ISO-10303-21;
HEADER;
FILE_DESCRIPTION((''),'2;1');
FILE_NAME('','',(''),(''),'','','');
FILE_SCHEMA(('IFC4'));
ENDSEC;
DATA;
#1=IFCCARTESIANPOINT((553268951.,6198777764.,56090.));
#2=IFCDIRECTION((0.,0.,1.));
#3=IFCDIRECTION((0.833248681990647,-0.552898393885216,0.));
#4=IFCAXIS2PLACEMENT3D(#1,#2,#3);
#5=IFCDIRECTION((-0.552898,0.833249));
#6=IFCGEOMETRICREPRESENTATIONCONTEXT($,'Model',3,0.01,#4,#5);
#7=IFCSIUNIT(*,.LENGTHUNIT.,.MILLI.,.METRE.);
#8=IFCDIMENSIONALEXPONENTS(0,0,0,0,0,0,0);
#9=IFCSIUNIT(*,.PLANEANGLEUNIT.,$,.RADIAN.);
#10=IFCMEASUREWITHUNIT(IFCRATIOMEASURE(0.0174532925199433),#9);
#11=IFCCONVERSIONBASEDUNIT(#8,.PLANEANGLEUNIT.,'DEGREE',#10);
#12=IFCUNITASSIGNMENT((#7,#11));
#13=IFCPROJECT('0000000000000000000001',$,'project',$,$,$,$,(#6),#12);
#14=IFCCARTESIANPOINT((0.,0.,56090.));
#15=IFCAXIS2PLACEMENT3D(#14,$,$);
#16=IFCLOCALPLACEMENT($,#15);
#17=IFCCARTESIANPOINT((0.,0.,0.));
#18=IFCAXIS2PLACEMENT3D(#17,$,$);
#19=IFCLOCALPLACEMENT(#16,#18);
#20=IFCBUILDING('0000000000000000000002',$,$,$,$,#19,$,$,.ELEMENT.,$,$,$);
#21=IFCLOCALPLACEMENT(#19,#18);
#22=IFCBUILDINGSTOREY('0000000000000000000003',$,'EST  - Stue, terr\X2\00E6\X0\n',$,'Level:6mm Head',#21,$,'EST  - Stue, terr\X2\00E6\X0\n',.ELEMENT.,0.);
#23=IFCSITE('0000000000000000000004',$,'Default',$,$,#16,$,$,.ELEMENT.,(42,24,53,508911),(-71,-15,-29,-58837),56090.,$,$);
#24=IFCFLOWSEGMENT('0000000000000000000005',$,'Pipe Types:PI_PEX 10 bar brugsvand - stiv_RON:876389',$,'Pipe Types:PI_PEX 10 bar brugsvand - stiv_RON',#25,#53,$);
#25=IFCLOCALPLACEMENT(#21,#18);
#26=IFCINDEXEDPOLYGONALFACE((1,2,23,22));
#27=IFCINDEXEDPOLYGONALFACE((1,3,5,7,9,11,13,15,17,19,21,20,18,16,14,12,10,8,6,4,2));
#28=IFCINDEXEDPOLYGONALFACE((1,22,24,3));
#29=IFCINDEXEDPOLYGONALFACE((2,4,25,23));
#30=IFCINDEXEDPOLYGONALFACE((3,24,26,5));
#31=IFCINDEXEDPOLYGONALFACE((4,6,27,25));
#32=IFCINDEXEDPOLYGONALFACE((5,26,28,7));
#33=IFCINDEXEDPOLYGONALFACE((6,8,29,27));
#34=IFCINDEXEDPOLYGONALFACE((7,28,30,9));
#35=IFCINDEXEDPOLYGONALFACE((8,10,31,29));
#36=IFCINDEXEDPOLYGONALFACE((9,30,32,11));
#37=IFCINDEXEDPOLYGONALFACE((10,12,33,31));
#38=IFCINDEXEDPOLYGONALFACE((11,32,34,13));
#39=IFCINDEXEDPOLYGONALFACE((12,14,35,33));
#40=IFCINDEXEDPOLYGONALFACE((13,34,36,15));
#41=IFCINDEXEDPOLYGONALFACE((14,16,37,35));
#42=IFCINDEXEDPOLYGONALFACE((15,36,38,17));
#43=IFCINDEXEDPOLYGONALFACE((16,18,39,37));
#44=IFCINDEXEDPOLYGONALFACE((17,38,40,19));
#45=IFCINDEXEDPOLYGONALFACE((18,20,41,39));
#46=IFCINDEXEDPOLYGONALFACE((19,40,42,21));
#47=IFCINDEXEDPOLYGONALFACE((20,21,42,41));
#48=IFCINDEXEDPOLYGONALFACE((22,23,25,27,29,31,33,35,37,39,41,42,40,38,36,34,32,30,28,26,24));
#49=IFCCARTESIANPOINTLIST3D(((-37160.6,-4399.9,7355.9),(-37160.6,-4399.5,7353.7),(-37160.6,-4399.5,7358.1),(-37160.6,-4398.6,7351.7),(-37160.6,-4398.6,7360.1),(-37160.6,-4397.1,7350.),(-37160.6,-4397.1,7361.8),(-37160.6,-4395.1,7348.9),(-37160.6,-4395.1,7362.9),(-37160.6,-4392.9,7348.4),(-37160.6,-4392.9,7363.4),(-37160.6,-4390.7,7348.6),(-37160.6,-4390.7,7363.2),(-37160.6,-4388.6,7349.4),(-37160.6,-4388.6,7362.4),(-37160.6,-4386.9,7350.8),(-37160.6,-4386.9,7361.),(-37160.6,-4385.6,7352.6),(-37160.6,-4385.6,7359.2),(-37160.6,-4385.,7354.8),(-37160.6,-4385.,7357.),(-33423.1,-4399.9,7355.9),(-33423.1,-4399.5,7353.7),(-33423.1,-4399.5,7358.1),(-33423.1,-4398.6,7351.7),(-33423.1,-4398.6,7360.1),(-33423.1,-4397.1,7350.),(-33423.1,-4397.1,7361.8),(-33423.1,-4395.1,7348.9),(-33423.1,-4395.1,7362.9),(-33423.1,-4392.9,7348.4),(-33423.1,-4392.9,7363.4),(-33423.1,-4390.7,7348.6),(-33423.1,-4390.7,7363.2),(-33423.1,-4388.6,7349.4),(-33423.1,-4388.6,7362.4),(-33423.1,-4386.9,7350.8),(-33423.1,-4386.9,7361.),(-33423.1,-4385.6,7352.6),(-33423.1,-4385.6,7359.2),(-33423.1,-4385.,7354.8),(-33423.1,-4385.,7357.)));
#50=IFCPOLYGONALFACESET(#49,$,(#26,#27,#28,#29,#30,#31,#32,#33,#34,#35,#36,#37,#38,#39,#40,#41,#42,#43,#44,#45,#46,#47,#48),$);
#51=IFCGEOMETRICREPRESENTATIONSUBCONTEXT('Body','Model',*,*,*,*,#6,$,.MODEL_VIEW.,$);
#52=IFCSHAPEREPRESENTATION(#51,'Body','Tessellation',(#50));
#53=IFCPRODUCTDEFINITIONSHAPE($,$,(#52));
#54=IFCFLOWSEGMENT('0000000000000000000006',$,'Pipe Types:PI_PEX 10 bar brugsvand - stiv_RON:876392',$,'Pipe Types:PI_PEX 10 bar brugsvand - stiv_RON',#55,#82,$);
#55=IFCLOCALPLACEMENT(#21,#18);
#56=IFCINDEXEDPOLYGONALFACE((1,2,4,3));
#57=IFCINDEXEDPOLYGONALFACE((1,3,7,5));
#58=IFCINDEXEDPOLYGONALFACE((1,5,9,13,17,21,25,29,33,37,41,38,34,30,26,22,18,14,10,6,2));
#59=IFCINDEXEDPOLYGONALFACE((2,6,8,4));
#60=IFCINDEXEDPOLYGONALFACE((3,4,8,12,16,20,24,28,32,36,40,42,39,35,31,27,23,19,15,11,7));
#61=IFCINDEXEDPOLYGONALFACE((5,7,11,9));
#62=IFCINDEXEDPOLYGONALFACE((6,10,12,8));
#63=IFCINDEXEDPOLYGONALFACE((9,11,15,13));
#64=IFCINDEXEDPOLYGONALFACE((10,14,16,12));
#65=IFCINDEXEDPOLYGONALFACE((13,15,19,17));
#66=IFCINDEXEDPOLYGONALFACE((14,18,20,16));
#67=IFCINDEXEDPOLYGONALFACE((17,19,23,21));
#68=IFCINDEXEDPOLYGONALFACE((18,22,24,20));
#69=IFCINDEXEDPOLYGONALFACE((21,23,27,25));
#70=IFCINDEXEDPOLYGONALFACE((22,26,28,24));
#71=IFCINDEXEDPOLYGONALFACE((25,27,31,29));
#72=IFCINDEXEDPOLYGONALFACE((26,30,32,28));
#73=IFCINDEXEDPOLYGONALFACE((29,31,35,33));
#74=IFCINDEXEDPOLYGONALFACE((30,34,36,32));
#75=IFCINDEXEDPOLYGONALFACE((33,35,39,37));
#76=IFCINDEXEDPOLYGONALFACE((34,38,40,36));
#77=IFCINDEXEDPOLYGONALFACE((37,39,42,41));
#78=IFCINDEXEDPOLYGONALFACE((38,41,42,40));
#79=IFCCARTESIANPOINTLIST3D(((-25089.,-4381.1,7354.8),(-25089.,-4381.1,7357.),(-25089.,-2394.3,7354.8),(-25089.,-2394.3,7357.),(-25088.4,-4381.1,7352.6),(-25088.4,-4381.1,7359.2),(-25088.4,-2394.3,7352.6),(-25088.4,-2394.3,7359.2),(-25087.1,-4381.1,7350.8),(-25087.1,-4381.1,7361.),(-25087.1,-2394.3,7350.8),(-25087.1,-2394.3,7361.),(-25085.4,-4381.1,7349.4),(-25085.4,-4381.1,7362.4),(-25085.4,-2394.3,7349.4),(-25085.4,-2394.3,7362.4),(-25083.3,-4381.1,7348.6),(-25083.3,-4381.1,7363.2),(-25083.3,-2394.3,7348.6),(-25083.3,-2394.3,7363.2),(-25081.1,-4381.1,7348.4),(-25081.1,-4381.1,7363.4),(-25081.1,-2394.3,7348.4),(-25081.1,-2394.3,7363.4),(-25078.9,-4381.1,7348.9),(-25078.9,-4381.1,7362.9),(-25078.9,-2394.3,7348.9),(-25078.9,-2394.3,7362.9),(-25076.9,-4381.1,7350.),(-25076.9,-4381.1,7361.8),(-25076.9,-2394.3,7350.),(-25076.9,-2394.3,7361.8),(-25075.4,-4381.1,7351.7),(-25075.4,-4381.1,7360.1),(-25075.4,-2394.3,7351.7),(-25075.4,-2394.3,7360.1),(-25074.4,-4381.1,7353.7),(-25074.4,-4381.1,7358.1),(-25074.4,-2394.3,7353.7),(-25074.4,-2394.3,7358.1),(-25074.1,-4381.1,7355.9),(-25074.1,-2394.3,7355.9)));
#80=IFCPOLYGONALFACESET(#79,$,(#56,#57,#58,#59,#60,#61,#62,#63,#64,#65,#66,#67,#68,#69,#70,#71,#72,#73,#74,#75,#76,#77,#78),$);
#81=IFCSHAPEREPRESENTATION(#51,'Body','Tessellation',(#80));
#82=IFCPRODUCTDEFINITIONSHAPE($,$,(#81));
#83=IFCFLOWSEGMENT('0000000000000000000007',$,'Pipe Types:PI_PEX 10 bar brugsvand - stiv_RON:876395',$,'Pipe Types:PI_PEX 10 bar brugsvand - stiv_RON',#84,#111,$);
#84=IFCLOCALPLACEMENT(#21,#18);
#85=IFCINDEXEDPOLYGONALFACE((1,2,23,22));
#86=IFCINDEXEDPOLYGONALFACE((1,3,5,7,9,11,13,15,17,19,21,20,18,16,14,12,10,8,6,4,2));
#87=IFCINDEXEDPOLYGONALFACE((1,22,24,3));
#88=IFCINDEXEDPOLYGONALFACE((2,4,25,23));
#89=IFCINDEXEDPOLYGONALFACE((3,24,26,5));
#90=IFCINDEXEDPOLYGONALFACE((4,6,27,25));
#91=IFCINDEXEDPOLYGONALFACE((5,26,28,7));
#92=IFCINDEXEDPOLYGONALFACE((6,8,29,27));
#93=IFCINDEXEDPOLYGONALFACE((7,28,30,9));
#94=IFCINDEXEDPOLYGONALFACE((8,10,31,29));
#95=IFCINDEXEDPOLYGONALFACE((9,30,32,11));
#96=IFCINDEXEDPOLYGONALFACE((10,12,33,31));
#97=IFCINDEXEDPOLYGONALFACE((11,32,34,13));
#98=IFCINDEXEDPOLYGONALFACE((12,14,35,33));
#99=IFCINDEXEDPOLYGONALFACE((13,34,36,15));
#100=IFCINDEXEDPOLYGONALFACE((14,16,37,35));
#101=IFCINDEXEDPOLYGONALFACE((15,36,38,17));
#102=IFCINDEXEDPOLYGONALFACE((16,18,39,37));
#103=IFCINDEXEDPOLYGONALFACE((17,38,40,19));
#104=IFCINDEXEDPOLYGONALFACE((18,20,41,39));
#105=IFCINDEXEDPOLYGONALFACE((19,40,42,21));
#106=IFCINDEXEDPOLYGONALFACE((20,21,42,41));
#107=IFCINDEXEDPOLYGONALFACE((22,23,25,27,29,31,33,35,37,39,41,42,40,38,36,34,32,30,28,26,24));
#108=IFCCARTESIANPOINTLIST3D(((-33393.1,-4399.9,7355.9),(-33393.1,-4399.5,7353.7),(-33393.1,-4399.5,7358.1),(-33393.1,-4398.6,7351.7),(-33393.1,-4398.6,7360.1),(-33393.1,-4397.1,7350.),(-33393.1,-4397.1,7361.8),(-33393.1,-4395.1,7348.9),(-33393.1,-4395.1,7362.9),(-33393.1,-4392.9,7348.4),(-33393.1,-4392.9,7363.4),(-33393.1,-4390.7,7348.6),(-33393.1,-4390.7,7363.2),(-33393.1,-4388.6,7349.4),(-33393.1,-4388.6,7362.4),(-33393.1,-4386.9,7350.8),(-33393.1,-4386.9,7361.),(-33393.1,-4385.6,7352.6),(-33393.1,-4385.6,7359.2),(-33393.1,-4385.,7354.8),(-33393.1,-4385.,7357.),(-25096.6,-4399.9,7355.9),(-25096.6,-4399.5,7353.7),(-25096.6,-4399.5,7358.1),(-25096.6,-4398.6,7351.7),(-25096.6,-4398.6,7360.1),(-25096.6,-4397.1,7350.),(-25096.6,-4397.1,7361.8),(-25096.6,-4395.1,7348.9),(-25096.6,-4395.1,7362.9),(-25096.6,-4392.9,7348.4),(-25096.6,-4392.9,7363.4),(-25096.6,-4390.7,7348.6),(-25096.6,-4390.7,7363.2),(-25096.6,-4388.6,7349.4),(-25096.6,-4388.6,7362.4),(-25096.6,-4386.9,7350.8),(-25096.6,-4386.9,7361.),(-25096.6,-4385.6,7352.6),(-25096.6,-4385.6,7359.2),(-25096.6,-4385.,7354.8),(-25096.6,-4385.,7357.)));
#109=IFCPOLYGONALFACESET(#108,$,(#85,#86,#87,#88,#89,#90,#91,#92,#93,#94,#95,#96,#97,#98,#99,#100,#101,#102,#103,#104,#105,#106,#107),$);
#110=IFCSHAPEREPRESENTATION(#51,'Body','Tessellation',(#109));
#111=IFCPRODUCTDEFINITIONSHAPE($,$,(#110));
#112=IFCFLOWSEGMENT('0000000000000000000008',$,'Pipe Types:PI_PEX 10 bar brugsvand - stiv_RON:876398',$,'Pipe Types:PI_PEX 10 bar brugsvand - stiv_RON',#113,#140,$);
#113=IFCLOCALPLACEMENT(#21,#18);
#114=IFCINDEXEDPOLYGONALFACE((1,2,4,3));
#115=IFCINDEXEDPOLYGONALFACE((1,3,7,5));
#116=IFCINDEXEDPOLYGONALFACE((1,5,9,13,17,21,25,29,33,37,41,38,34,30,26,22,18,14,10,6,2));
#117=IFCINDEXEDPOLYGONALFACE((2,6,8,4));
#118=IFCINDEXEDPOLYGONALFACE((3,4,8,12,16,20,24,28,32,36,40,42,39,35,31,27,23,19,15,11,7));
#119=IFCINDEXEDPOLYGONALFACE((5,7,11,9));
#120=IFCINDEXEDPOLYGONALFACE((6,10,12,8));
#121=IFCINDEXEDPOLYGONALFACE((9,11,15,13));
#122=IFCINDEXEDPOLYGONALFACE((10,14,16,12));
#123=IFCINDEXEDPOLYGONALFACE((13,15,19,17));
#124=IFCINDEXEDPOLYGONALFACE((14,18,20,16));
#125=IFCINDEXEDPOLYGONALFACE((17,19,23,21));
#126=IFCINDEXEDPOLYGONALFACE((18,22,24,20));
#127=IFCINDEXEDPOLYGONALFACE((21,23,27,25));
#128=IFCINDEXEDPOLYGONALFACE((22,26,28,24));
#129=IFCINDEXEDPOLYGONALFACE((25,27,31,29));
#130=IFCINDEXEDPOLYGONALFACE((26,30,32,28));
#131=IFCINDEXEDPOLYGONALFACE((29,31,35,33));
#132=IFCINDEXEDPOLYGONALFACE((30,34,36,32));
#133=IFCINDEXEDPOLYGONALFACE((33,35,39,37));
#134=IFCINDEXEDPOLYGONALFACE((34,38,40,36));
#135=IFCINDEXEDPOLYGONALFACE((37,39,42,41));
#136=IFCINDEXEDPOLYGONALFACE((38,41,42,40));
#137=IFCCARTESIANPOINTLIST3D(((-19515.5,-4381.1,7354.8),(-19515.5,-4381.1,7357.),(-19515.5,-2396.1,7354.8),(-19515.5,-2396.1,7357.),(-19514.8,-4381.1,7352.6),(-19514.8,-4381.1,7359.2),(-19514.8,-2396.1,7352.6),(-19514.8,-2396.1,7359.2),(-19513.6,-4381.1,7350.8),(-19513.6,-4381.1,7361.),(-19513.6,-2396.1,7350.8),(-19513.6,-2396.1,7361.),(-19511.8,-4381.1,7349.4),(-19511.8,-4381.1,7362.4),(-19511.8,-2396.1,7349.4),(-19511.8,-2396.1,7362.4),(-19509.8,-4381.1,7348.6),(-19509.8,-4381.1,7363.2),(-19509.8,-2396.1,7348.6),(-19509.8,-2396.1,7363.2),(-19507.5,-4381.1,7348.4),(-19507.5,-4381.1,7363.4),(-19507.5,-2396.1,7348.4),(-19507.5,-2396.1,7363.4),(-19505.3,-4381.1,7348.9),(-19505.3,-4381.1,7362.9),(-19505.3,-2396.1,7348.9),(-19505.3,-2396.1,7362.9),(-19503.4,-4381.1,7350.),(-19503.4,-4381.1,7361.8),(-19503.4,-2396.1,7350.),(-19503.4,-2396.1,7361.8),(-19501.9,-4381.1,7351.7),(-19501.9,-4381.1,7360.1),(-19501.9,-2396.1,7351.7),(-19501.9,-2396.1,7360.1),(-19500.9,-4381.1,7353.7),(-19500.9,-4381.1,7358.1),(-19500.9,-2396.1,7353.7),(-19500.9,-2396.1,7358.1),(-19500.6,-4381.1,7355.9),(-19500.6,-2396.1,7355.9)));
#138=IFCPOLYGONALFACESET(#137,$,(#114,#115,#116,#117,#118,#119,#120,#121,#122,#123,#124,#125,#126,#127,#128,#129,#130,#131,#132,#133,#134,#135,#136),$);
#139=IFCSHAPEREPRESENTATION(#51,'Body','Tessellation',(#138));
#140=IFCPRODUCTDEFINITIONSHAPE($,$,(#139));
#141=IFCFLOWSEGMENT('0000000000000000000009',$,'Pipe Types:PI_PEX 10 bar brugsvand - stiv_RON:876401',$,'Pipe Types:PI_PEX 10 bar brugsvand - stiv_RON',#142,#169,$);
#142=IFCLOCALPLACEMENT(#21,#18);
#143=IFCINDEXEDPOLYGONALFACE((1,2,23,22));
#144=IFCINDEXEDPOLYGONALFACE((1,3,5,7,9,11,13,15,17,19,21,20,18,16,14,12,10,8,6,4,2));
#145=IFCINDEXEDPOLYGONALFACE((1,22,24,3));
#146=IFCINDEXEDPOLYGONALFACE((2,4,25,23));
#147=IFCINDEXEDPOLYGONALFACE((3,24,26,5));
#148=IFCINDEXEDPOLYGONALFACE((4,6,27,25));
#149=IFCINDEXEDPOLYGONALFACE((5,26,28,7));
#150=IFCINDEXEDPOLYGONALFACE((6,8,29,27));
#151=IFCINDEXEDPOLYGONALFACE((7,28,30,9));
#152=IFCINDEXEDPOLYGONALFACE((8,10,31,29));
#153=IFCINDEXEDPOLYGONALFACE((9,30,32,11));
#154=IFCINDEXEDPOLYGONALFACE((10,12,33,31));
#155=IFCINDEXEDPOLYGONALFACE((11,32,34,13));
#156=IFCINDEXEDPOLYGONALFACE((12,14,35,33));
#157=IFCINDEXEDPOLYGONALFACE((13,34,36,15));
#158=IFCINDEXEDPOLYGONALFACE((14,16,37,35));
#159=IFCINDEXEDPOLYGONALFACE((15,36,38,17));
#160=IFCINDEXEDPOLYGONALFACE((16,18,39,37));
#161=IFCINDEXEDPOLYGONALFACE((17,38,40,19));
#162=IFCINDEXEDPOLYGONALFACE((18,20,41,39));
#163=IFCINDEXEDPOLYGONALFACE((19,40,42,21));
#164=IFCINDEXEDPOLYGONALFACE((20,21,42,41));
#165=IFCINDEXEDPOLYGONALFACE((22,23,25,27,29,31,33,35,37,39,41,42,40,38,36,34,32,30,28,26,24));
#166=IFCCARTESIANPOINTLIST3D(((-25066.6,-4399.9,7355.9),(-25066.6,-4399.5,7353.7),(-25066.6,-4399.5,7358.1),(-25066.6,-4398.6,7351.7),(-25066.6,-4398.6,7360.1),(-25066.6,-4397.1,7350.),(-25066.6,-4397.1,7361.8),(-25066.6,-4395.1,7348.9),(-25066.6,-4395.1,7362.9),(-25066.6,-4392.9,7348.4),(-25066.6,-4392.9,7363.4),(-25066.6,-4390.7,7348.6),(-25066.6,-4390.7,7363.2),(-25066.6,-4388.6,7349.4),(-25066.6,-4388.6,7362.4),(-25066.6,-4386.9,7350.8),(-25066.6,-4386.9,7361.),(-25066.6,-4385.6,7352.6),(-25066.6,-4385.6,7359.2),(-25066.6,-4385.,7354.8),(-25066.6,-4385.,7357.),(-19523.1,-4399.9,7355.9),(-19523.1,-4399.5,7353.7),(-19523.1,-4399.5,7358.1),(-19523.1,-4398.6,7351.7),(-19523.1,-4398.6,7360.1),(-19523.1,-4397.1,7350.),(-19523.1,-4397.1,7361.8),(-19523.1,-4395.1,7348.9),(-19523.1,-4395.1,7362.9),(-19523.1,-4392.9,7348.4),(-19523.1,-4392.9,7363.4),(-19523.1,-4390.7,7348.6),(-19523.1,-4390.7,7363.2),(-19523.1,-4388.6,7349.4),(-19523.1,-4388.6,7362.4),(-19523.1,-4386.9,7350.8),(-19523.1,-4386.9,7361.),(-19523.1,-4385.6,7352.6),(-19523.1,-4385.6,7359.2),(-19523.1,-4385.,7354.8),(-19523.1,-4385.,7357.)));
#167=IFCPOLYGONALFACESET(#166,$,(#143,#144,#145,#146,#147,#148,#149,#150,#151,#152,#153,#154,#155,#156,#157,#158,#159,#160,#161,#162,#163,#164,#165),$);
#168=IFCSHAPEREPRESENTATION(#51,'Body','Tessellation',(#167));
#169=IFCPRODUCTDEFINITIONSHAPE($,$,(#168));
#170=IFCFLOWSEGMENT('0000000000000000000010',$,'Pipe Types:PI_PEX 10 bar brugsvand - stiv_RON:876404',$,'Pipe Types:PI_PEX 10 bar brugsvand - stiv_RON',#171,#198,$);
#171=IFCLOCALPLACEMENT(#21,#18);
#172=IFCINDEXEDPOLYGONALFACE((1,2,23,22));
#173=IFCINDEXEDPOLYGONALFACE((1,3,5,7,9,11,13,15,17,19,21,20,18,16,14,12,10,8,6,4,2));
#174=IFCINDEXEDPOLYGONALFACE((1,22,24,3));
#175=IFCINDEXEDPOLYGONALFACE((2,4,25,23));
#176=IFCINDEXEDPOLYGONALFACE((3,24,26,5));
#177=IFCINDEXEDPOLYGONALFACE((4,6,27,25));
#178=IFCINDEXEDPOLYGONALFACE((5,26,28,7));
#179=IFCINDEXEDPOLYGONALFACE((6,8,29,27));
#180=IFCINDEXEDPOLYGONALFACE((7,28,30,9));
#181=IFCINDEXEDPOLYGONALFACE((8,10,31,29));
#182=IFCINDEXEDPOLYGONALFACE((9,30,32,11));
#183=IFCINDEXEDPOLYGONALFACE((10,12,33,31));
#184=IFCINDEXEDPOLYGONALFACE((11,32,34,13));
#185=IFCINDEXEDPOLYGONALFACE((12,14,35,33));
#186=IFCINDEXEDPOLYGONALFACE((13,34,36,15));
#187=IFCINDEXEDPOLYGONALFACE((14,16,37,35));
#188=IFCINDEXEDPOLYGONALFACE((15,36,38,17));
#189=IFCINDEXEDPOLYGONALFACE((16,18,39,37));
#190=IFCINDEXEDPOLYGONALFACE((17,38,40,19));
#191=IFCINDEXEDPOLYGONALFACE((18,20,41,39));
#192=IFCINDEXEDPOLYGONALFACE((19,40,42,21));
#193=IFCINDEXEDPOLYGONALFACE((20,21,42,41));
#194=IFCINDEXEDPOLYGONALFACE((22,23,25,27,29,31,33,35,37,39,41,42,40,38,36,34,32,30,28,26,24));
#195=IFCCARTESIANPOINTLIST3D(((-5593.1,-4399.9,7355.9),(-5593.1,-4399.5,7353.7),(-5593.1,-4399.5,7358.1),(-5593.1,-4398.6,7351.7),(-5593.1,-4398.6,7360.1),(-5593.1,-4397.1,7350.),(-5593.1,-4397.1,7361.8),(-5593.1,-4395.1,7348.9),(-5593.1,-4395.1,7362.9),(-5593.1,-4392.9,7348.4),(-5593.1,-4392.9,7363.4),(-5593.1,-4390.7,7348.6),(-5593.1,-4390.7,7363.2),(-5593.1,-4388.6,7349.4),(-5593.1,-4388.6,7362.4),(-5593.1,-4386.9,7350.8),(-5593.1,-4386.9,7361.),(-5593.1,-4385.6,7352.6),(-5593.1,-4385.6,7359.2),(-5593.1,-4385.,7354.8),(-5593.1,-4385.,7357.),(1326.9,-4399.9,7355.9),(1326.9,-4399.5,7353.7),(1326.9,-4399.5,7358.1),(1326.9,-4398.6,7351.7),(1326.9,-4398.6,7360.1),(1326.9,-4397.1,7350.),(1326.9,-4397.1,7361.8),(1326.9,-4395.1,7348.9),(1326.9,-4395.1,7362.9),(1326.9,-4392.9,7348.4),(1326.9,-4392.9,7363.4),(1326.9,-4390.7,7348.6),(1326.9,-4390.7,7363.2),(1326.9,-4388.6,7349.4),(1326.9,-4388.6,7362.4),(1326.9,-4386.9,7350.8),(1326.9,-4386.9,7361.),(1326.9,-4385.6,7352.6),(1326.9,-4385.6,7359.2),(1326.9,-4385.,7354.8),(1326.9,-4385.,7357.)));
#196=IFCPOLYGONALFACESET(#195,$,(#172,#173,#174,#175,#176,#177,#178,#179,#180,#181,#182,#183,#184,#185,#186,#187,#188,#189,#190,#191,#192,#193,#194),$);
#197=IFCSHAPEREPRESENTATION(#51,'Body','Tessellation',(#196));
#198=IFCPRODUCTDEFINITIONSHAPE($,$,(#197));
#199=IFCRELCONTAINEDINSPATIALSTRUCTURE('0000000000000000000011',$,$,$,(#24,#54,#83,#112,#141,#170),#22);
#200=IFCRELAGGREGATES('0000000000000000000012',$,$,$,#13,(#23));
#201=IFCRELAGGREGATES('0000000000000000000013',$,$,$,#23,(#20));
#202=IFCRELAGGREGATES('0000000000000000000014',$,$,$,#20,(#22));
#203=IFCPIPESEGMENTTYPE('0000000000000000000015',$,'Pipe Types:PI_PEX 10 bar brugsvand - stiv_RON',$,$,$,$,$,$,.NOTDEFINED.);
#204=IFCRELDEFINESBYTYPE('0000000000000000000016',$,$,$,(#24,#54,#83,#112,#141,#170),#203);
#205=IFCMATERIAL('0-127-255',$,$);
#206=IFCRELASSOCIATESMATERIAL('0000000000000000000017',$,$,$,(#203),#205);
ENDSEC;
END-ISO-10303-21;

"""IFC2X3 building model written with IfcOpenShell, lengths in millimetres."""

from ifc_helpers import new_model, entity, si_unit, converted_unit, direction, frame, origin, origin_2d_with_axis, place, context, subcontext, project, spatial, circle, extrude, material, type_object, element, save


model = new_model("IFC2X3")

# Units and contexts
model_context = context("Model", 3, precision=0.01, world=frame((553268951.0, 6198777764.0, 56090.0), z_axis=(0.0, 0.0, 1.0), x_axis=(0.833248681990647, -0.552898393885216, 0.0)), true_north=direction((-0.552898, 0.833249)))
body_context = subcontext(model_context, "Body", "Model", "MODEL_VIEW")
ifc_project = project(units=[si_unit("LENGTHUNIT", "METRE", prefix="MILLI"), converted_unit("PLANEANGLEUNIT", "DEGREE", entity("IfcRatioMeasure", 0.0174532925199433), si_unit("PLANEANGLEUNIT", "RADIAN"), dimensions=[0, 0, 0, 0, 0, 0, 0])], contexts=[model_context])

# Site, building, storey
site_placement = place(None, frame((0.0, 0.0, 56090.0)))
site = spatial("IfcSite", under=ifc_project, at=site_placement, Name="Default", CompositionType="ELEMENT", RefLatitude=(42, 24, 53, 508911), RefLongitude=(-71, -15, -29, -58837), RefElevation=56090.0)
building_placement = place(site_placement, origin())
building = spatial("IfcBuilding", under=site, at=building_placement, CompositionType="ELEMENT")
storey_placement = place(building_placement, frame((0.0, 0.0, 0.0)))
storey = spatial("IfcBuildingStorey", under=building, at=storey_placement, Name="EST  - Stue, terræn", ObjectType="Level:6mm Head", LongName="EST  - Stue, terræn", CompositionType="ELEMENT", Elevation=0.0)

# Flow segments
ifc_material_1 = material(Name="0-127-255")
pipe_segment_type_1 = type_object("IfcPipeSegmentType", Name="Pipe Types:PI_PEX 10 bar brugsvand - stiv_RON", PredefinedType="NOTDEFINED", material=ifc_material_1)
flow_segment_1_placement = place(storey_placement, origin())
element("IfcFlowSegment", 1, at=flow_segment_1_placement, inside=storey, type_object=pipe_segment_type_1, Name="Pipe Types:PI_PEX 10 bar brugsvand - stiv_RON:876389", ObjectType="Pipe Types:PI_PEX 10 bar brugsvand - stiv_RON", context=body_context, shape_type="SweptSolid", body=[
    extrude(circle(Radius=7.5, at=origin_2d_with_axis()), frame((-37160.6, -4392.4, 7355.9), z_axis=(1.0, 0.0, 0.0), x_axis=(0.0, -1.0, 0.0)), (0.0, 0.0, 1.0), 3737.5),
])
flow_segment_2_placement = place(storey_placement, origin())
element("IfcFlowSegment", 2, at=flow_segment_2_placement, inside=storey, type_object=pipe_segment_type_1, Name="Pipe Types:PI_PEX 10 bar brugsvand - stiv_RON:876392", ObjectType="Pipe Types:PI_PEX 10 bar brugsvand - stiv_RON", context=body_context, shape_type="SweptSolid", body=[
    extrude(circle(Radius=7.5, at=origin_2d_with_axis()), frame((-25081.6, -4381.1, 7355.9), z_axis=(0.0, 1.0, 0.0), x_axis=(1.0, 0.0, 0.0)), (0.0, 0.0, 1.0), 1986.8),
])
flow_segment_3_placement = place(storey_placement, origin())
element("IfcFlowSegment", 3, at=flow_segment_3_placement, inside=storey, type_object=pipe_segment_type_1, Name="Pipe Types:PI_PEX 10 bar brugsvand - stiv_RON:876395", ObjectType="Pipe Types:PI_PEX 10 bar brugsvand - stiv_RON", context=body_context, shape_type="SweptSolid", body=[
    extrude(circle(Radius=7.5, at=origin_2d_with_axis()), frame((-33393.1, -4392.4, 7355.9), z_axis=(1.0, 0.0, 0.0), x_axis=(0.0, -1.0, 0.0)), (0.0, 0.0, 1.0), 8296.5),
])
flow_segment_4_placement = place(storey_placement, origin())
element("IfcFlowSegment", 4, at=flow_segment_4_placement, inside=storey, type_object=pipe_segment_type_1, Name="Pipe Types:PI_PEX 10 bar brugsvand - stiv_RON:876398", ObjectType="Pipe Types:PI_PEX 10 bar brugsvand - stiv_RON", context=body_context, shape_type="SweptSolid", body=[
    extrude(circle(Radius=7.5, at=origin_2d_with_axis()), frame((-19508.1, -4381.1, 7355.9), z_axis=(0.0, 1.0, 0.0), x_axis=(1.0, 0.0, 0.0)), (0.0, 0.0, 1.0), 1985.0),
])
flow_segment_5_placement = place(storey_placement, origin())
element("IfcFlowSegment", 5, at=flow_segment_5_placement, inside=storey, type_object=pipe_segment_type_1, Name="Pipe Types:PI_PEX 10 bar brugsvand - stiv_RON:876401", ObjectType="Pipe Types:PI_PEX 10 bar brugsvand - stiv_RON", context=body_context, shape_type="SweptSolid", body=[
    extrude(circle(Radius=7.5, at=origin_2d_with_axis()), frame((-25066.6, -4392.4, 7355.9), z_axis=(1.0, 0.0, 0.0), x_axis=(0.0, -1.0, 0.0)), (0.0, 0.0, 1.0), 5543.5),
])
flow_segment_6_placement = place(storey_placement, origin())
element("IfcFlowSegment", 6, at=flow_segment_6_placement, inside=storey, type_object=pipe_segment_type_1, Name="Pipe Types:PI_PEX 10 bar brugsvand - stiv_RON:876404", ObjectType="Pipe Types:PI_PEX 10 bar brugsvand - stiv_RON", context=body_context, shape_type="SweptSolid", body=[
    extrude(circle(Radius=7.5, at=origin_2d_with_axis()), frame((-5593.1, -4392.4, 7355.9), z_axis=(1.0, 0.0, 0.0), x_axis=(0.0, -1.0, 0.0)), (0.0, 0.0, 1.0), 6920.0),
])

save(model, "model.ifc")
